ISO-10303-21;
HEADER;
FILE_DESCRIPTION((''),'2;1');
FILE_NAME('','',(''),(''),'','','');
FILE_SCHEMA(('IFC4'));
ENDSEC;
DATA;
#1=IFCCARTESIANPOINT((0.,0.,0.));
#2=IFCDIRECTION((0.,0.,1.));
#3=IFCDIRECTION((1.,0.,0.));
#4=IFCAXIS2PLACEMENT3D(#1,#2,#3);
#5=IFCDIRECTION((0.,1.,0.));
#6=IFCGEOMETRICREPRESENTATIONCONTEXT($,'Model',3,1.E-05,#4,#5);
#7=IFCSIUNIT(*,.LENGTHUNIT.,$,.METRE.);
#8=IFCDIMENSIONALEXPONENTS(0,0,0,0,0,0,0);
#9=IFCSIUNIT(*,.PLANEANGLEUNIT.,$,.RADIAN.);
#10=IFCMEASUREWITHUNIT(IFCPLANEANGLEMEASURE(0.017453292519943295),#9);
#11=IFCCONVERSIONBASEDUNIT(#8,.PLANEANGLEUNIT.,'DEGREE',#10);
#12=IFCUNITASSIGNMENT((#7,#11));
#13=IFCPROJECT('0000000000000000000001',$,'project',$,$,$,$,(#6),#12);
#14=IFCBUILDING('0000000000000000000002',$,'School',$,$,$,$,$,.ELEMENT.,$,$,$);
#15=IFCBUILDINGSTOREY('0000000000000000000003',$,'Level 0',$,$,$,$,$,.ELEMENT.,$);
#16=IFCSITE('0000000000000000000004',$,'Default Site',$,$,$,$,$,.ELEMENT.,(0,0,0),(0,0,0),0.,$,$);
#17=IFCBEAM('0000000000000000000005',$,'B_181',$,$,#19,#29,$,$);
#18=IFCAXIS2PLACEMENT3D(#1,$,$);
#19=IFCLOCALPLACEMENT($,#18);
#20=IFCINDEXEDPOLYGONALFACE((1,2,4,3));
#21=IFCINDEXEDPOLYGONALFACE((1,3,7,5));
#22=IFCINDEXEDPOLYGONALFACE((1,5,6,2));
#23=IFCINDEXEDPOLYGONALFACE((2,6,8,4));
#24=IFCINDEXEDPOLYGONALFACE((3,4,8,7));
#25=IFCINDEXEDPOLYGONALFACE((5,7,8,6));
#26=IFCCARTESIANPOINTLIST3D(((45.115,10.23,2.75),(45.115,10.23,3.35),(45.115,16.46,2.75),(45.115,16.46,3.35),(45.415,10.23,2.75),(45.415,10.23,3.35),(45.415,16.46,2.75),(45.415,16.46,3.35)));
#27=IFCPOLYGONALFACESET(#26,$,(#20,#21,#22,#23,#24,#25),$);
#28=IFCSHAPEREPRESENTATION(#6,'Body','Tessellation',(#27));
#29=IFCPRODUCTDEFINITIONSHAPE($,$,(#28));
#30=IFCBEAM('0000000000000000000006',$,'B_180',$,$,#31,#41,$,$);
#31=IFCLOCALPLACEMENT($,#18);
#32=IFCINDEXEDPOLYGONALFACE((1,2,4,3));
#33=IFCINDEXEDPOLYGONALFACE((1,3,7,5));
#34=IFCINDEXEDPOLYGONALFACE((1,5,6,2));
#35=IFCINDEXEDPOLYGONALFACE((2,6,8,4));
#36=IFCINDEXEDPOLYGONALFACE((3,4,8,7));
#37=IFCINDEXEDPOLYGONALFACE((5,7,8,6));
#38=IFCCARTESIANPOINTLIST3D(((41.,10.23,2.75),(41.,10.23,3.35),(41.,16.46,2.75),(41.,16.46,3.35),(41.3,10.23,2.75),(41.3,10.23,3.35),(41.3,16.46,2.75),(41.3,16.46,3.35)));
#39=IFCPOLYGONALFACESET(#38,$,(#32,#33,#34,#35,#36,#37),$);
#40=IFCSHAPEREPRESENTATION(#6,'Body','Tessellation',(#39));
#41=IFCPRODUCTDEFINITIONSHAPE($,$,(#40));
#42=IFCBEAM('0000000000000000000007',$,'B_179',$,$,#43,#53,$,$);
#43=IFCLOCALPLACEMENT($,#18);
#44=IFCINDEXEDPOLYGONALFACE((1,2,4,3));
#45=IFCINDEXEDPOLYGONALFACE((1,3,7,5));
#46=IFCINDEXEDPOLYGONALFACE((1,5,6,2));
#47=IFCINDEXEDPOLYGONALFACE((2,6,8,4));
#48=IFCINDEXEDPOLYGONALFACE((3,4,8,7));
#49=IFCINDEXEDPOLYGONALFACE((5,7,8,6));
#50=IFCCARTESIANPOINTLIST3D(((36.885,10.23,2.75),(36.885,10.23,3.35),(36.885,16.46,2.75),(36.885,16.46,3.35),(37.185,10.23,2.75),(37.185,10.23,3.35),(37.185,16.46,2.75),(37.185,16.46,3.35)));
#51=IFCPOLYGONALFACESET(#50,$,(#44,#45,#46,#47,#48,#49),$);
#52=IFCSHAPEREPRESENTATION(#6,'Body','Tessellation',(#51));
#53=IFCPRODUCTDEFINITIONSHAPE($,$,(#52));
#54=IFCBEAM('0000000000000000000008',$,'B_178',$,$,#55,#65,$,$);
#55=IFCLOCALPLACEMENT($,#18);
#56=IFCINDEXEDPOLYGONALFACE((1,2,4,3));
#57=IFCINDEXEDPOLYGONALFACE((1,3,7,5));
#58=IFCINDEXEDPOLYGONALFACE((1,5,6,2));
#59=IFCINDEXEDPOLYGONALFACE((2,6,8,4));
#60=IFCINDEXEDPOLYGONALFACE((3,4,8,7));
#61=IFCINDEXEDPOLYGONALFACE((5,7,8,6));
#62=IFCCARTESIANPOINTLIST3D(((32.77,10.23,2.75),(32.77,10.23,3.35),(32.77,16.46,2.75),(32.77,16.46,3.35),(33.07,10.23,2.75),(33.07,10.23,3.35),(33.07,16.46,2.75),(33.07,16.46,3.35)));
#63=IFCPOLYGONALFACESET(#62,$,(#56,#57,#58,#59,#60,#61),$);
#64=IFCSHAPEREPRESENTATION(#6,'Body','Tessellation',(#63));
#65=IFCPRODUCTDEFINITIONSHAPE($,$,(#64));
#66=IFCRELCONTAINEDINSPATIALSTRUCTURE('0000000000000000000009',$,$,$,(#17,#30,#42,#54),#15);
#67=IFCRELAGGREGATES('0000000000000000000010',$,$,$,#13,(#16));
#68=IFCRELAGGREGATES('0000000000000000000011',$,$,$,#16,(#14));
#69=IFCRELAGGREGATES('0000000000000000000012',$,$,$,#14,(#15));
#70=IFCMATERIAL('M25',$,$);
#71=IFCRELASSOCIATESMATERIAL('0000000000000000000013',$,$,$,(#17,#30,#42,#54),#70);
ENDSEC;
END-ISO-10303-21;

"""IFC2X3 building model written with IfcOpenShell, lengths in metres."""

from ifc_helpers import new_model, entity, si_unit, converted_unit, direction, frame, frame_2d, origin_with_axes, place, context, project, spatial, rectangle, extrude, material, element, save


model = new_model("IFC2X3")

# Units and contexts
model_context = context("Model", 3, precision=1e-05, world=origin_with_axes(), true_north=direction((0.0, 1.0, 0.0)))
ifc_project = project(units=[si_unit("LENGTHUNIT", "METRE"), converted_unit("PLANEANGLEUNIT", "DEGREE", entity("IfcPlaneAngleMeasure", 0.017453292519943295), si_unit("PLANEANGLEUNIT", "RADIAN"), dimensions=[0, 0, 0, 0, 0, 0, 0])], contexts=[model_context])

# Site, building, storey
site = spatial("IfcSite", under=ifc_project, Name="Default Site", CompositionType="ELEMENT", RefLatitude=(0, 0, 0), RefLongitude=(0, 0, 0), RefElevation=0.0)
building = spatial("IfcBuilding", under=site, Name="School", CompositionType="ELEMENT")
storey = spatial("IfcBuildingStorey", under=building, Name="Level 0", CompositionType="ELEMENT")

# Beams
ifc_material = material(Name="M25")
placement = place(None, origin_with_axes())
element("IfcBeam", 1, at=placement, inside=storey, material=ifc_material, Name="B_181", context=model_context, shape_type="SweptSolid", body=[
    extrude(rectangle(XDim=0.3, YDim=0.6, at=frame_2d((0.0, 0.0), x_axis=(0.0, 1.0, 0.0))), frame((45.265, 10.23, 3.05), z_axis=(0.0, 1.0, 0.0), x_axis=(0.0, 0.0, -1.0)), (0.0, 0.0, 1.0), 6.23),
])
element("IfcBeam", 2, at=placement, inside=storey, material=ifc_material, Name="B_180", context=model_context, shape_type="SweptSolid", body=[
    extrude(rectangle(XDim=0.3, YDim=0.6, at=frame_2d((0.0, 0.0), x_axis=(0.0, 1.0, 0.0))), frame((41.15, 10.23, 3.05), z_axis=(0.0, 1.0, 0.0), x_axis=(0.0, 0.0, -1.0)), (0.0, 0.0, 1.0), 6.23),
])
element("IfcBeam", 3, at=placement, inside=storey, material=ifc_material, Name="B_179", context=model_context, shape_type="SweptSolid", body=[
    extrude(rectangle(XDim=0.3, YDim=0.6, at=frame_2d((0.0, 0.0), x_axis=(0.0, 1.0, 0.0))), frame((37.035, 10.23, 3.05), z_axis=(0.0, 1.0, 0.0), x_axis=(0.0, 0.0, -1.0)), (0.0, 0.0, 1.0), 6.23),
])
element("IfcBeam", 4, at=placement, inside=storey, material=ifc_material, Name="B_178", context=model_context, shape_type="SweptSolid", body=[
    extrude(rectangle(XDim=0.3, YDim=0.6, at=frame_2d((0.0, 0.0), x_axis=(0.0, 1.0, 0.0))), frame((32.92, 10.23, 3.05), z_axis=(0.0, 1.0, 0.0), x_axis=(0.0, 0.0, -1.0)), (0.0, 0.0, 1.0), 6.23),
])

save(model, "model.ifc")
